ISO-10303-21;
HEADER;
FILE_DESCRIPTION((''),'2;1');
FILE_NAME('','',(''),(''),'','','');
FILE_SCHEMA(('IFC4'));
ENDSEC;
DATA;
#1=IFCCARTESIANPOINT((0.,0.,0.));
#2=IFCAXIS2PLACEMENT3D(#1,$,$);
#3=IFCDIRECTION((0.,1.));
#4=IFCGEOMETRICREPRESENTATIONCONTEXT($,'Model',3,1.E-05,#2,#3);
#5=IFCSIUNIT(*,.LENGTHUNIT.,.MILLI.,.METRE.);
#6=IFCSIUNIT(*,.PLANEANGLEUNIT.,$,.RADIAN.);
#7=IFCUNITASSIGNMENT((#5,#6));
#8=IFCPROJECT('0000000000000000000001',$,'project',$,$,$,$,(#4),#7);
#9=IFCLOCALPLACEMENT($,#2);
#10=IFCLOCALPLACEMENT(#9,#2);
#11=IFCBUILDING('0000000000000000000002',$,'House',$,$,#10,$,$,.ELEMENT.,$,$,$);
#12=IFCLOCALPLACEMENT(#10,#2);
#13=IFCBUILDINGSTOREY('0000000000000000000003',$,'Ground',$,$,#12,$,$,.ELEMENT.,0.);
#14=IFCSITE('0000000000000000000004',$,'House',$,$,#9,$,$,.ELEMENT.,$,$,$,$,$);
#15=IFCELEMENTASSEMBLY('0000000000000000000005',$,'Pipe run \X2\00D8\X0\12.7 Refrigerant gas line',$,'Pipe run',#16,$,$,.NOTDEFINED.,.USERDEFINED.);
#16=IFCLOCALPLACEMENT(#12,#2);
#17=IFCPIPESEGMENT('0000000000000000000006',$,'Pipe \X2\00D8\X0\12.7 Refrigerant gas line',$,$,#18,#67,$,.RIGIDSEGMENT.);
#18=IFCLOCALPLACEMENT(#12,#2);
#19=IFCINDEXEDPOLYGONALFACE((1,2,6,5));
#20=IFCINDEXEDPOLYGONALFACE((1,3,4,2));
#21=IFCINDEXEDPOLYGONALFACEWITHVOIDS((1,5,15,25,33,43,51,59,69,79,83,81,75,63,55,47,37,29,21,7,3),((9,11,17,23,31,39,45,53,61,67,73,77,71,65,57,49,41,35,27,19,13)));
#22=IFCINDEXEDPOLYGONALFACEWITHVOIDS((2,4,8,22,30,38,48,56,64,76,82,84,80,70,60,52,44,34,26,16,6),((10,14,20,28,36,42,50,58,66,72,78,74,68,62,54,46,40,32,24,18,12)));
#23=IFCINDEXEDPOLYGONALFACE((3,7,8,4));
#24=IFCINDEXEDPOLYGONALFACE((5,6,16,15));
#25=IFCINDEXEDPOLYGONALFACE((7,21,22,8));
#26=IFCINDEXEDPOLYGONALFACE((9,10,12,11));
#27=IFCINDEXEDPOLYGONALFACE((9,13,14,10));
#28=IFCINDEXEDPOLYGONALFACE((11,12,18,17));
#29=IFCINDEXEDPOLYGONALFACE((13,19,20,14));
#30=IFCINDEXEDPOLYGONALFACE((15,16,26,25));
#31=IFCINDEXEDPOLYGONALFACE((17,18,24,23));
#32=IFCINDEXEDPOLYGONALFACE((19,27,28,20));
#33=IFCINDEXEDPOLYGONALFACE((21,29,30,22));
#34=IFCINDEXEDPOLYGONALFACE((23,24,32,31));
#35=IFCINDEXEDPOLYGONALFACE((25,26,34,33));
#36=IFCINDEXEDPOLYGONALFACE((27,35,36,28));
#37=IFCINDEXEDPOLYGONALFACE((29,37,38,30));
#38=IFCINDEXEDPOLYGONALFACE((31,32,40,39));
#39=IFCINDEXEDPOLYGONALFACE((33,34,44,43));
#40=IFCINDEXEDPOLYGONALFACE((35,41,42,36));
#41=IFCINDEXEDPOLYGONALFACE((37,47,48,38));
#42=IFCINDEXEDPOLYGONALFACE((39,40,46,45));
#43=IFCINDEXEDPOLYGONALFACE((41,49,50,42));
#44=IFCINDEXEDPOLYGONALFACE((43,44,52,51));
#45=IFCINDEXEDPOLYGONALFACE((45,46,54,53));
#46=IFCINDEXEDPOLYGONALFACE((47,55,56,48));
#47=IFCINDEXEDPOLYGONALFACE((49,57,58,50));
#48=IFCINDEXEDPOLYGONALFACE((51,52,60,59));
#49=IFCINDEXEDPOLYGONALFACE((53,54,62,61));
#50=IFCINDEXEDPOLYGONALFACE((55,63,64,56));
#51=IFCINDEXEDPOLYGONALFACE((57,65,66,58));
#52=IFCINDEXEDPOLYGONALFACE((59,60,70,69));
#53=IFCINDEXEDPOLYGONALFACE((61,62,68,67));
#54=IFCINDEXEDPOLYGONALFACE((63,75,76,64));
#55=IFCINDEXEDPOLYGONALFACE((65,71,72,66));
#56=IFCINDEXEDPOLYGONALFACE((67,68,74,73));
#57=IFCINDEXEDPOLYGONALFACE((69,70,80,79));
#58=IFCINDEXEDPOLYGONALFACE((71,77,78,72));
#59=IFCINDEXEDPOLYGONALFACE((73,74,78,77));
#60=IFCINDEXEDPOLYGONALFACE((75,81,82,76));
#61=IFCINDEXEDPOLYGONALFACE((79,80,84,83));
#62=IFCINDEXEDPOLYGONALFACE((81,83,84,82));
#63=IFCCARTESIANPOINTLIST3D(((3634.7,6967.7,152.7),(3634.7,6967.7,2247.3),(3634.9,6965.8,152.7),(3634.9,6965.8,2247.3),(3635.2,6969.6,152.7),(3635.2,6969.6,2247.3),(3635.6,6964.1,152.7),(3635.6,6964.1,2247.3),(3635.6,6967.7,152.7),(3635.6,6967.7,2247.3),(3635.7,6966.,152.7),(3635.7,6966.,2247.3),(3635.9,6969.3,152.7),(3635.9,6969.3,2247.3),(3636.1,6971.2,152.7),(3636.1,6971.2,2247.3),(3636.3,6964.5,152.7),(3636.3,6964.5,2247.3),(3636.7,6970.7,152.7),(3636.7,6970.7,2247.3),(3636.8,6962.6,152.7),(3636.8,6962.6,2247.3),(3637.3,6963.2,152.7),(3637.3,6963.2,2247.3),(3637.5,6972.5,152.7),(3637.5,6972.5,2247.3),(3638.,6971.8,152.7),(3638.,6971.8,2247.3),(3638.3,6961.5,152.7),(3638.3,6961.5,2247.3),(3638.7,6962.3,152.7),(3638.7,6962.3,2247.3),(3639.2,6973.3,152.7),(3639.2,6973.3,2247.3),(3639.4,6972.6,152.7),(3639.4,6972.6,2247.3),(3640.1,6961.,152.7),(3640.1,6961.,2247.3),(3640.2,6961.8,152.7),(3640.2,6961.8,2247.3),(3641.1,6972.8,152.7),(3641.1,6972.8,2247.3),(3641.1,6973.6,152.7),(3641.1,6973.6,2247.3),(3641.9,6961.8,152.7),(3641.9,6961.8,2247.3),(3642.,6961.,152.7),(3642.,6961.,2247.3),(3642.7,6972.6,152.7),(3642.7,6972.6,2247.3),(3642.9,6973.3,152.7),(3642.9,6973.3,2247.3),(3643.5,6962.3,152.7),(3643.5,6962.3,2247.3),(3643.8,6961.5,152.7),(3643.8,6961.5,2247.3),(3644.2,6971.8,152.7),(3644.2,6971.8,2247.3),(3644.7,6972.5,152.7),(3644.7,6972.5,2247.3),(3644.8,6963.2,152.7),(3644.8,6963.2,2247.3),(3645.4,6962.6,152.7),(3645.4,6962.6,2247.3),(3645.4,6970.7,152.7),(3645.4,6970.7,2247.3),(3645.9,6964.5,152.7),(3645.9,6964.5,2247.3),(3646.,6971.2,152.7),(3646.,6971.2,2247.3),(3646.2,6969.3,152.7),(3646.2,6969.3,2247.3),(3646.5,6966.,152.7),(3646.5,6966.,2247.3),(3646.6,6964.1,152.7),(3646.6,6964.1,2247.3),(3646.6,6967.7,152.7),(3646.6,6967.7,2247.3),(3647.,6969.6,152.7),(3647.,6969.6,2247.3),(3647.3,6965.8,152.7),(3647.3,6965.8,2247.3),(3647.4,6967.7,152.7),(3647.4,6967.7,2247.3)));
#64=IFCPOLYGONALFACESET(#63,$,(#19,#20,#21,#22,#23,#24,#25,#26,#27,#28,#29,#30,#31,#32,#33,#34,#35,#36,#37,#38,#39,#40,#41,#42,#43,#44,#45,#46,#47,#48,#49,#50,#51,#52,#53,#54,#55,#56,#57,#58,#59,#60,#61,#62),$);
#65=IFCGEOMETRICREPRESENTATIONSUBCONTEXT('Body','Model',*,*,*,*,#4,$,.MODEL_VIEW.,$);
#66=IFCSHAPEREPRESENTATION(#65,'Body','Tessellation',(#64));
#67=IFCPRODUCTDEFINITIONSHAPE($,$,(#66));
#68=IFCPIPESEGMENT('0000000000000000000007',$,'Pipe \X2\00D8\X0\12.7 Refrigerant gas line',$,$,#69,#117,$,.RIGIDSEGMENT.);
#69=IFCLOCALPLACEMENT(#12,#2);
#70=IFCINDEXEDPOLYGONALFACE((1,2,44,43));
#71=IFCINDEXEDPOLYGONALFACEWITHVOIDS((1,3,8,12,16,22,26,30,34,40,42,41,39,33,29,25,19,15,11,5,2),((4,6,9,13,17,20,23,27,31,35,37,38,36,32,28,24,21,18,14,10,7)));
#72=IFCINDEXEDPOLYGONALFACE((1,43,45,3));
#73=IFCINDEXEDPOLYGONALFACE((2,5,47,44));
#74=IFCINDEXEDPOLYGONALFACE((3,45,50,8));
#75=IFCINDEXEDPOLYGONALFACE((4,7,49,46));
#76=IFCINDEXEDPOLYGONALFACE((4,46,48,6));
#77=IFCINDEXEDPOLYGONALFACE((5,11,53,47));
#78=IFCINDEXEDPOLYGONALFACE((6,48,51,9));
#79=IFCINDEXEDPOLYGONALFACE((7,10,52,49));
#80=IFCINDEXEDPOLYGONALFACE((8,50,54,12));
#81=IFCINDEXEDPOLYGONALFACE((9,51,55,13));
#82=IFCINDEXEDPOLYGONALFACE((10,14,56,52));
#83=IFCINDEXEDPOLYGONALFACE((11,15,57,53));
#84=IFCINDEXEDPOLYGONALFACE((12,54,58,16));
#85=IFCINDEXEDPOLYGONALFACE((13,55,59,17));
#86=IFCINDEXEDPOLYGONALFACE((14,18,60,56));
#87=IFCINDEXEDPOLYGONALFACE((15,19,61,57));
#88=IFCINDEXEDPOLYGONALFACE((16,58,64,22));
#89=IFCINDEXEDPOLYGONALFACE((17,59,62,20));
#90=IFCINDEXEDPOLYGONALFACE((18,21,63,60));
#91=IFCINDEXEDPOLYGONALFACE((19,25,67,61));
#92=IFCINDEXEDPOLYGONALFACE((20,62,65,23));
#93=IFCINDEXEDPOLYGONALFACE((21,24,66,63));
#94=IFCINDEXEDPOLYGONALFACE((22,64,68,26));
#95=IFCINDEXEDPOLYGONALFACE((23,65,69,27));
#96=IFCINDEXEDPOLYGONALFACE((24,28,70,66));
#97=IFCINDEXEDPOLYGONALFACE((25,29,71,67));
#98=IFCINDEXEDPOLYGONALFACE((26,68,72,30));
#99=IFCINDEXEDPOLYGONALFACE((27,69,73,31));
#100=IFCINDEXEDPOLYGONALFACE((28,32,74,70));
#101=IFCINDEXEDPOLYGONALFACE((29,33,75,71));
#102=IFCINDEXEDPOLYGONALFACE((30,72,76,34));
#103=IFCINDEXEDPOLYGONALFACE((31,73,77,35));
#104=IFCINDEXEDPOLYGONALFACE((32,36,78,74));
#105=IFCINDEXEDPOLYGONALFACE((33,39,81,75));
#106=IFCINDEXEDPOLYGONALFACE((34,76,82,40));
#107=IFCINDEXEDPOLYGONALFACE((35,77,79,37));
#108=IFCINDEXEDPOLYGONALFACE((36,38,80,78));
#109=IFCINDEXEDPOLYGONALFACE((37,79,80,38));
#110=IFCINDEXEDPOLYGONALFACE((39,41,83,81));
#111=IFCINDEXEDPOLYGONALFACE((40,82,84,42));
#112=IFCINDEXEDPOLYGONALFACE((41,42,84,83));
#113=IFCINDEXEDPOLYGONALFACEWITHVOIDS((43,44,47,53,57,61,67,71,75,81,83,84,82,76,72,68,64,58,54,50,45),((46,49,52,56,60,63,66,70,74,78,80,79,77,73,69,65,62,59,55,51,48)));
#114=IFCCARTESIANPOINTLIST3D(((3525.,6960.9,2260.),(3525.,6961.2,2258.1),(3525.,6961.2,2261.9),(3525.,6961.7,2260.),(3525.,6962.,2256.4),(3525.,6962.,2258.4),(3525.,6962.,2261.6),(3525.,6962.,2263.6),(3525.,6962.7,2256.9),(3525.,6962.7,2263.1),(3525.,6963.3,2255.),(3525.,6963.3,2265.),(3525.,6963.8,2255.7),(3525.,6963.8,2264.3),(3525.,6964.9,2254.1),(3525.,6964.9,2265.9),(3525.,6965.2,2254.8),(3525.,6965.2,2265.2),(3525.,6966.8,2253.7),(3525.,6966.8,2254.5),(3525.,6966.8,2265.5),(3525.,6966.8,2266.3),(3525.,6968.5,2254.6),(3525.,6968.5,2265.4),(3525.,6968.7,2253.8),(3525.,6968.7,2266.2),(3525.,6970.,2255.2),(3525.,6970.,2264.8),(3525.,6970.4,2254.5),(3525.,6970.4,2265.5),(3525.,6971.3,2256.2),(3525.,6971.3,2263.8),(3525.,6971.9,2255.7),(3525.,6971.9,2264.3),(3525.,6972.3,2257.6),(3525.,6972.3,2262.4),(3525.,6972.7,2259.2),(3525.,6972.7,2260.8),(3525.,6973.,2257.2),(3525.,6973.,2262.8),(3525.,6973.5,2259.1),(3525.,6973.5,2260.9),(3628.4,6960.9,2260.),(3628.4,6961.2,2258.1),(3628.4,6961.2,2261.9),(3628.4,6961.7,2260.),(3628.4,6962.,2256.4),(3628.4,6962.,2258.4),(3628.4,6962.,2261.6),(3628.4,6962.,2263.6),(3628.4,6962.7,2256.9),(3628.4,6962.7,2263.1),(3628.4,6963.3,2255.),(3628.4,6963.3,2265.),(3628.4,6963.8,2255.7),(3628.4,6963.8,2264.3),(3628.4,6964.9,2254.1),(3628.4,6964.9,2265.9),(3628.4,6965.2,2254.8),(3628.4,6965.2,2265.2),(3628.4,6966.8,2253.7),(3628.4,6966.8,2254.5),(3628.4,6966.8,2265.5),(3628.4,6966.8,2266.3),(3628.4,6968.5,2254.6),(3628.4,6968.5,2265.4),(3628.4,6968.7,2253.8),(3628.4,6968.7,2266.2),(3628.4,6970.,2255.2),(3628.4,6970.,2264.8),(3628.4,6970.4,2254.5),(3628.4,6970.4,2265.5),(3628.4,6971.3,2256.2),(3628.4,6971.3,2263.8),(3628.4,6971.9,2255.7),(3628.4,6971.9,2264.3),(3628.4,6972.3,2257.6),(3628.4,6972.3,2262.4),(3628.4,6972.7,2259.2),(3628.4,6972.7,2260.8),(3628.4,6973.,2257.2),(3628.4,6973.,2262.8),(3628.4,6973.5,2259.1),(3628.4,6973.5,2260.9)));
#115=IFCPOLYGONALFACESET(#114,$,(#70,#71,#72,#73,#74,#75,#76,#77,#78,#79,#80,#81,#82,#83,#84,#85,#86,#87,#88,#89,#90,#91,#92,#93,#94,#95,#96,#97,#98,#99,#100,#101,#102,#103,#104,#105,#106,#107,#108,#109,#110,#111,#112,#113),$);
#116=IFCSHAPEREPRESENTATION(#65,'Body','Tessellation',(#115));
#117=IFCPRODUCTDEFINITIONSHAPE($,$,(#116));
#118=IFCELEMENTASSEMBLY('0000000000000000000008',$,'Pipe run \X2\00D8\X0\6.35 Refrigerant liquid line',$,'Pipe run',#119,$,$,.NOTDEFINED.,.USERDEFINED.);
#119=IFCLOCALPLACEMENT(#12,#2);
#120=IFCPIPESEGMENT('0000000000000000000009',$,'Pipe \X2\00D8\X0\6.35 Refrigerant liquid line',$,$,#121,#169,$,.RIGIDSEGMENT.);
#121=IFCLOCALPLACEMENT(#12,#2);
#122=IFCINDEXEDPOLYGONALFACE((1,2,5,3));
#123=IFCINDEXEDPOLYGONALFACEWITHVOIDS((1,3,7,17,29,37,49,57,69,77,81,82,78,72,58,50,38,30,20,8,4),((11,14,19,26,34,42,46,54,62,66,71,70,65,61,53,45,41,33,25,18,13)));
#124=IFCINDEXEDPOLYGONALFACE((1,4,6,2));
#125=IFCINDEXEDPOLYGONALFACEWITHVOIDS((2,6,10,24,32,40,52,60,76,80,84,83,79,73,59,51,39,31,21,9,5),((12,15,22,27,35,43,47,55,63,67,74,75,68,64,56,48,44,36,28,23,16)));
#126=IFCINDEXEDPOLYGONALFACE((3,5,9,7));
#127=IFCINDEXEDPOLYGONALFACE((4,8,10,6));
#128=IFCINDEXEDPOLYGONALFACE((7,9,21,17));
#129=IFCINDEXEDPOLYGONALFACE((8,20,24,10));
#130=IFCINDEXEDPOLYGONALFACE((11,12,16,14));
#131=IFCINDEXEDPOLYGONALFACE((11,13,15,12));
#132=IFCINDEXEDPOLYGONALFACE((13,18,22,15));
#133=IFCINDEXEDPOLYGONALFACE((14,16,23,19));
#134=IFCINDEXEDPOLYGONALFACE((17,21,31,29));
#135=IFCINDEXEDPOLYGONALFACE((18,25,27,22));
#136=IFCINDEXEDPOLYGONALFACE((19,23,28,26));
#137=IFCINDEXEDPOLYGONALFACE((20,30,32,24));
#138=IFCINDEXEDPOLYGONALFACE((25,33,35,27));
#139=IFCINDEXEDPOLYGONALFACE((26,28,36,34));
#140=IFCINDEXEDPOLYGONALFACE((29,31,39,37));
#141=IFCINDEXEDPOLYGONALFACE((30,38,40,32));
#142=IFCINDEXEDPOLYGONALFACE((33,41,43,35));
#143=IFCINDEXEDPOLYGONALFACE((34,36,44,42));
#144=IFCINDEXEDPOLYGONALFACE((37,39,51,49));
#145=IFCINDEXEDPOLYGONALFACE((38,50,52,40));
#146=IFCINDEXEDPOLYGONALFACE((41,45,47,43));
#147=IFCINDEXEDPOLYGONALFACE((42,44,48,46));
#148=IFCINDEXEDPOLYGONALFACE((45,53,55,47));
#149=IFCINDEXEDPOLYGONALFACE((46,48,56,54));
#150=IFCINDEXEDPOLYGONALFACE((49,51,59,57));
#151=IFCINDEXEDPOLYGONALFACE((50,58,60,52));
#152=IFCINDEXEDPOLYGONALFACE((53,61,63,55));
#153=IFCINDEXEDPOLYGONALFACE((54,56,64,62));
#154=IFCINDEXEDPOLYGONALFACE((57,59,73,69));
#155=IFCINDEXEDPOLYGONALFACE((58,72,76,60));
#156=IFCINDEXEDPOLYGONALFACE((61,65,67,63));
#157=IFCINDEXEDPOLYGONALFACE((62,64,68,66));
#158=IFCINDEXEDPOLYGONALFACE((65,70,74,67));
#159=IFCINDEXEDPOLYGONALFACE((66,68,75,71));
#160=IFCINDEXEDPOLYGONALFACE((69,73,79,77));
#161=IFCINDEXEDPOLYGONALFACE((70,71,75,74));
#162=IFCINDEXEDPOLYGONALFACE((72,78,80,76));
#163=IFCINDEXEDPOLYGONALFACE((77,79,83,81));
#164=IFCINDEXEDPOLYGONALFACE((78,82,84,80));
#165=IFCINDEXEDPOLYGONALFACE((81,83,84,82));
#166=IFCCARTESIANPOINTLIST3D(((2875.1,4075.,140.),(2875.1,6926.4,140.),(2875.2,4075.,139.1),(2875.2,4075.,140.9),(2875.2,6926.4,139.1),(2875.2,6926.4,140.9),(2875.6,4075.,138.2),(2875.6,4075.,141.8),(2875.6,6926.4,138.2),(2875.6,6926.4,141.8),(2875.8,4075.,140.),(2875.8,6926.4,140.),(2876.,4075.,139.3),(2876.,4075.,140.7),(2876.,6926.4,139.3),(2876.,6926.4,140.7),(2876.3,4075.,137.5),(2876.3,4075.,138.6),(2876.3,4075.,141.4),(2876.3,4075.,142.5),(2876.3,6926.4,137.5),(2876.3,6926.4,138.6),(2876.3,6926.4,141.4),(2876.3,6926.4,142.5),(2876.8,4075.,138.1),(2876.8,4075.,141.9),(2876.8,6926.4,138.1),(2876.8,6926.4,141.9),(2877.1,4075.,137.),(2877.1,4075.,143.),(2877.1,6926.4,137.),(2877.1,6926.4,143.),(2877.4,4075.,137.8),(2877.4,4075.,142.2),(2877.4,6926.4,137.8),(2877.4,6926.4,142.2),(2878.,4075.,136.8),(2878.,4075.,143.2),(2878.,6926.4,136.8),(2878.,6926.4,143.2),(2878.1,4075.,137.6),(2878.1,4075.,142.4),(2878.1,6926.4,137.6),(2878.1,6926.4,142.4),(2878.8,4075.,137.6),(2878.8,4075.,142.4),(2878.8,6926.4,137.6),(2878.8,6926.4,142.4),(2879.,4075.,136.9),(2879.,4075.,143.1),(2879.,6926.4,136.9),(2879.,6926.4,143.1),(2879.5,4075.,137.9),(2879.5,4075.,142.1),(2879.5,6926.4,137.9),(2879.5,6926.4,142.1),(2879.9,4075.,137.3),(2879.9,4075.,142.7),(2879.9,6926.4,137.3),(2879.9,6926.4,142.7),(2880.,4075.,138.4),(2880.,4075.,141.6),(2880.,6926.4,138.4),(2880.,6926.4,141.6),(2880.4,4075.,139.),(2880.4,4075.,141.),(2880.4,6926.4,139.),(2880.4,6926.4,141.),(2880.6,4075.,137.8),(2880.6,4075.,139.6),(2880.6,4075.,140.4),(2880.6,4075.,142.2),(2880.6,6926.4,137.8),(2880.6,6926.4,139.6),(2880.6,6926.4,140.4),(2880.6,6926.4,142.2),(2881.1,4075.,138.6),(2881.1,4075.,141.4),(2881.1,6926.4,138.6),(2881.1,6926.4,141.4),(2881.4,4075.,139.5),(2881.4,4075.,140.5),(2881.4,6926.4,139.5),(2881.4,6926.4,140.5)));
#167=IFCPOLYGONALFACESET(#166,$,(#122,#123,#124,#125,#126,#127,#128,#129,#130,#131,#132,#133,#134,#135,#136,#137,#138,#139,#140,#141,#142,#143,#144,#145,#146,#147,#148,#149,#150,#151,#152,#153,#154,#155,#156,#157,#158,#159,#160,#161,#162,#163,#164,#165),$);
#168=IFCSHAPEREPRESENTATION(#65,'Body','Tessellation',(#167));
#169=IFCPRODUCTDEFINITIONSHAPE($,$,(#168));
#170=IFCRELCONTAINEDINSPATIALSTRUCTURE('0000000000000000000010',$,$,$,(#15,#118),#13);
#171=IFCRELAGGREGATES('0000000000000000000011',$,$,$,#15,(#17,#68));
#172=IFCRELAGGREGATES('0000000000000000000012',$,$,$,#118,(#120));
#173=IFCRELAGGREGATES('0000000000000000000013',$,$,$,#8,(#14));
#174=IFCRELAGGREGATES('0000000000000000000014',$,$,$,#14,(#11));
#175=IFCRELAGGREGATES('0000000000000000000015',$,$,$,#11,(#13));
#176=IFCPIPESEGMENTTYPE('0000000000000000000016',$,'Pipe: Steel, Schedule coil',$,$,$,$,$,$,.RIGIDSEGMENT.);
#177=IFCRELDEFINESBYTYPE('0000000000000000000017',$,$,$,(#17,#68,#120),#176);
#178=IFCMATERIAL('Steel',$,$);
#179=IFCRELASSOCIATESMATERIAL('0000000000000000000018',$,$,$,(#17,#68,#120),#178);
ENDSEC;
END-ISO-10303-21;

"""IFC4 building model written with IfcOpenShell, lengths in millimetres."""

from ifc_helpers import new_model, si_unit, direction, frame, origin, origin_with_axes, origin_2d, place, context, subcontext, project, spatial, hollow_circle, extrude, material, type_object, element, aggregate, save


model = new_model("IFC4")

# Units and contexts
model_context = context("Model", 3, precision=1e-05, world=origin(), true_north=direction((0.0, 1.0)))
body_context = subcontext(model_context, "Body", "Model", "MODEL_VIEW")
ifc_project = project(units=[si_unit("LENGTHUNIT", "METRE", prefix="MILLI"), si_unit("PLANEANGLEUNIT", "RADIAN")], contexts=[model_context])

# Site, building, storey
site_placement = place(None, origin())
site = spatial("IfcSite", under=ifc_project, at=site_placement, Name="House", CompositionType="ELEMENT")
building_placement = place(site_placement, origin())
building = spatial("IfcBuilding", under=site, at=building_placement, Name="House", CompositionType="ELEMENT")
storey_placement = place(building_placement, origin())
storey = spatial("IfcBuildingStorey", under=building, at=storey_placement, Name="Ground", CompositionType="ELEMENT", Elevation=0.0)

# Element assemblies, pipe segments
ifc_material = material(Name="Steel")
pipe_segment_type = type_object("IfcPipeSegmentType", Name="Pipe: Steel, Schedule coil", PredefinedType="RIGIDSEGMENT")
assembly_1_placement = place(storey_placement, origin_with_axes())
assembly_1 = element("IfcElementAssembly", 1, at=assembly_1_placement, inside=storey, Name="Pipe run Ø12.7 Refrigerant gas line", ObjectType="Pipe run", AssemblyPlace="NOTDEFINED", PredefinedType="USERDEFINED")
pipe_segment_1_placement = place(storey_placement, origin_with_axes())
pipe_segment_1 = element("IfcPipeSegment", 2, at=pipe_segment_1_placement, type_object=pipe_segment_type, material=ifc_material, Name="Pipe Ø12.7 Refrigerant gas line", PredefinedType="RIGIDSEGMENT", context=body_context, shape_type="SweptSolid", body=[
    extrude(hollow_circle(Radius=6.3, WallThickness=0.8, at=origin_2d()), frame((3641.1, 6967.3, 152.7), z_axis=(0.0, 0.0, 1.0), x_axis=(0.0, 1.0, 0.0)), (0.0, 0.0, 1.0), 2094.6),
])
pipe_segment_2_placement = place(storey_placement, origin_with_axes())
pipe_segment_2 = element("IfcPipeSegment", 3, at=pipe_segment_2_placement, type_object=pipe_segment_type, material=ifc_material, Name="Pipe Ø12.7 Refrigerant gas line", PredefinedType="RIGIDSEGMENT", context=body_context, shape_type="SweptSolid", body=[
    extrude(hollow_circle(Radius=6.3, WallThickness=0.8, at=origin_2d()), frame((3628.4, 6967.3, 2260.0), z_axis=(-1.0, 0.0, 0.0), x_axis=(0.0, -1.0, 0.0)), (0.0, 0.0, 1.0), 103.4),
])
assembly_2_placement = place(storey_placement, origin_with_axes())
assembly_2 = element("IfcElementAssembly", 4, at=assembly_2_placement, inside=storey, Name="Pipe run Ø6.35 Refrigerant liquid line", ObjectType="Pipe run", AssemblyPlace="NOTDEFINED", PredefinedType="USERDEFINED")
pipe_segment_3_placement = place(storey_placement, origin_with_axes())
pipe_segment_3 = element("IfcPipeSegment", 5, at=pipe_segment_3_placement, type_object=pipe_segment_type, material=ifc_material, Name="Pipe Ø6.35 Refrigerant liquid line", PredefinedType="RIGIDSEGMENT", context=body_context, shape_type="SweptSolid", body=[
    extrude(hollow_circle(Radius=3.2, WallThickness=0.8, at=origin_2d()), frame((2878.3, 4075.0, 140.0), z_axis=(0.0, 1.0, 0.0), x_axis=(-1.0, 0.0, 0.0)), (0.0, 0.0, 1.0), 2851.4),
])

aggregate(assembly_1, [pipe_segment_1, pipe_segment_2])
aggregate(assembly_2, [pipe_segment_3])

save(model, "model.ifc")
